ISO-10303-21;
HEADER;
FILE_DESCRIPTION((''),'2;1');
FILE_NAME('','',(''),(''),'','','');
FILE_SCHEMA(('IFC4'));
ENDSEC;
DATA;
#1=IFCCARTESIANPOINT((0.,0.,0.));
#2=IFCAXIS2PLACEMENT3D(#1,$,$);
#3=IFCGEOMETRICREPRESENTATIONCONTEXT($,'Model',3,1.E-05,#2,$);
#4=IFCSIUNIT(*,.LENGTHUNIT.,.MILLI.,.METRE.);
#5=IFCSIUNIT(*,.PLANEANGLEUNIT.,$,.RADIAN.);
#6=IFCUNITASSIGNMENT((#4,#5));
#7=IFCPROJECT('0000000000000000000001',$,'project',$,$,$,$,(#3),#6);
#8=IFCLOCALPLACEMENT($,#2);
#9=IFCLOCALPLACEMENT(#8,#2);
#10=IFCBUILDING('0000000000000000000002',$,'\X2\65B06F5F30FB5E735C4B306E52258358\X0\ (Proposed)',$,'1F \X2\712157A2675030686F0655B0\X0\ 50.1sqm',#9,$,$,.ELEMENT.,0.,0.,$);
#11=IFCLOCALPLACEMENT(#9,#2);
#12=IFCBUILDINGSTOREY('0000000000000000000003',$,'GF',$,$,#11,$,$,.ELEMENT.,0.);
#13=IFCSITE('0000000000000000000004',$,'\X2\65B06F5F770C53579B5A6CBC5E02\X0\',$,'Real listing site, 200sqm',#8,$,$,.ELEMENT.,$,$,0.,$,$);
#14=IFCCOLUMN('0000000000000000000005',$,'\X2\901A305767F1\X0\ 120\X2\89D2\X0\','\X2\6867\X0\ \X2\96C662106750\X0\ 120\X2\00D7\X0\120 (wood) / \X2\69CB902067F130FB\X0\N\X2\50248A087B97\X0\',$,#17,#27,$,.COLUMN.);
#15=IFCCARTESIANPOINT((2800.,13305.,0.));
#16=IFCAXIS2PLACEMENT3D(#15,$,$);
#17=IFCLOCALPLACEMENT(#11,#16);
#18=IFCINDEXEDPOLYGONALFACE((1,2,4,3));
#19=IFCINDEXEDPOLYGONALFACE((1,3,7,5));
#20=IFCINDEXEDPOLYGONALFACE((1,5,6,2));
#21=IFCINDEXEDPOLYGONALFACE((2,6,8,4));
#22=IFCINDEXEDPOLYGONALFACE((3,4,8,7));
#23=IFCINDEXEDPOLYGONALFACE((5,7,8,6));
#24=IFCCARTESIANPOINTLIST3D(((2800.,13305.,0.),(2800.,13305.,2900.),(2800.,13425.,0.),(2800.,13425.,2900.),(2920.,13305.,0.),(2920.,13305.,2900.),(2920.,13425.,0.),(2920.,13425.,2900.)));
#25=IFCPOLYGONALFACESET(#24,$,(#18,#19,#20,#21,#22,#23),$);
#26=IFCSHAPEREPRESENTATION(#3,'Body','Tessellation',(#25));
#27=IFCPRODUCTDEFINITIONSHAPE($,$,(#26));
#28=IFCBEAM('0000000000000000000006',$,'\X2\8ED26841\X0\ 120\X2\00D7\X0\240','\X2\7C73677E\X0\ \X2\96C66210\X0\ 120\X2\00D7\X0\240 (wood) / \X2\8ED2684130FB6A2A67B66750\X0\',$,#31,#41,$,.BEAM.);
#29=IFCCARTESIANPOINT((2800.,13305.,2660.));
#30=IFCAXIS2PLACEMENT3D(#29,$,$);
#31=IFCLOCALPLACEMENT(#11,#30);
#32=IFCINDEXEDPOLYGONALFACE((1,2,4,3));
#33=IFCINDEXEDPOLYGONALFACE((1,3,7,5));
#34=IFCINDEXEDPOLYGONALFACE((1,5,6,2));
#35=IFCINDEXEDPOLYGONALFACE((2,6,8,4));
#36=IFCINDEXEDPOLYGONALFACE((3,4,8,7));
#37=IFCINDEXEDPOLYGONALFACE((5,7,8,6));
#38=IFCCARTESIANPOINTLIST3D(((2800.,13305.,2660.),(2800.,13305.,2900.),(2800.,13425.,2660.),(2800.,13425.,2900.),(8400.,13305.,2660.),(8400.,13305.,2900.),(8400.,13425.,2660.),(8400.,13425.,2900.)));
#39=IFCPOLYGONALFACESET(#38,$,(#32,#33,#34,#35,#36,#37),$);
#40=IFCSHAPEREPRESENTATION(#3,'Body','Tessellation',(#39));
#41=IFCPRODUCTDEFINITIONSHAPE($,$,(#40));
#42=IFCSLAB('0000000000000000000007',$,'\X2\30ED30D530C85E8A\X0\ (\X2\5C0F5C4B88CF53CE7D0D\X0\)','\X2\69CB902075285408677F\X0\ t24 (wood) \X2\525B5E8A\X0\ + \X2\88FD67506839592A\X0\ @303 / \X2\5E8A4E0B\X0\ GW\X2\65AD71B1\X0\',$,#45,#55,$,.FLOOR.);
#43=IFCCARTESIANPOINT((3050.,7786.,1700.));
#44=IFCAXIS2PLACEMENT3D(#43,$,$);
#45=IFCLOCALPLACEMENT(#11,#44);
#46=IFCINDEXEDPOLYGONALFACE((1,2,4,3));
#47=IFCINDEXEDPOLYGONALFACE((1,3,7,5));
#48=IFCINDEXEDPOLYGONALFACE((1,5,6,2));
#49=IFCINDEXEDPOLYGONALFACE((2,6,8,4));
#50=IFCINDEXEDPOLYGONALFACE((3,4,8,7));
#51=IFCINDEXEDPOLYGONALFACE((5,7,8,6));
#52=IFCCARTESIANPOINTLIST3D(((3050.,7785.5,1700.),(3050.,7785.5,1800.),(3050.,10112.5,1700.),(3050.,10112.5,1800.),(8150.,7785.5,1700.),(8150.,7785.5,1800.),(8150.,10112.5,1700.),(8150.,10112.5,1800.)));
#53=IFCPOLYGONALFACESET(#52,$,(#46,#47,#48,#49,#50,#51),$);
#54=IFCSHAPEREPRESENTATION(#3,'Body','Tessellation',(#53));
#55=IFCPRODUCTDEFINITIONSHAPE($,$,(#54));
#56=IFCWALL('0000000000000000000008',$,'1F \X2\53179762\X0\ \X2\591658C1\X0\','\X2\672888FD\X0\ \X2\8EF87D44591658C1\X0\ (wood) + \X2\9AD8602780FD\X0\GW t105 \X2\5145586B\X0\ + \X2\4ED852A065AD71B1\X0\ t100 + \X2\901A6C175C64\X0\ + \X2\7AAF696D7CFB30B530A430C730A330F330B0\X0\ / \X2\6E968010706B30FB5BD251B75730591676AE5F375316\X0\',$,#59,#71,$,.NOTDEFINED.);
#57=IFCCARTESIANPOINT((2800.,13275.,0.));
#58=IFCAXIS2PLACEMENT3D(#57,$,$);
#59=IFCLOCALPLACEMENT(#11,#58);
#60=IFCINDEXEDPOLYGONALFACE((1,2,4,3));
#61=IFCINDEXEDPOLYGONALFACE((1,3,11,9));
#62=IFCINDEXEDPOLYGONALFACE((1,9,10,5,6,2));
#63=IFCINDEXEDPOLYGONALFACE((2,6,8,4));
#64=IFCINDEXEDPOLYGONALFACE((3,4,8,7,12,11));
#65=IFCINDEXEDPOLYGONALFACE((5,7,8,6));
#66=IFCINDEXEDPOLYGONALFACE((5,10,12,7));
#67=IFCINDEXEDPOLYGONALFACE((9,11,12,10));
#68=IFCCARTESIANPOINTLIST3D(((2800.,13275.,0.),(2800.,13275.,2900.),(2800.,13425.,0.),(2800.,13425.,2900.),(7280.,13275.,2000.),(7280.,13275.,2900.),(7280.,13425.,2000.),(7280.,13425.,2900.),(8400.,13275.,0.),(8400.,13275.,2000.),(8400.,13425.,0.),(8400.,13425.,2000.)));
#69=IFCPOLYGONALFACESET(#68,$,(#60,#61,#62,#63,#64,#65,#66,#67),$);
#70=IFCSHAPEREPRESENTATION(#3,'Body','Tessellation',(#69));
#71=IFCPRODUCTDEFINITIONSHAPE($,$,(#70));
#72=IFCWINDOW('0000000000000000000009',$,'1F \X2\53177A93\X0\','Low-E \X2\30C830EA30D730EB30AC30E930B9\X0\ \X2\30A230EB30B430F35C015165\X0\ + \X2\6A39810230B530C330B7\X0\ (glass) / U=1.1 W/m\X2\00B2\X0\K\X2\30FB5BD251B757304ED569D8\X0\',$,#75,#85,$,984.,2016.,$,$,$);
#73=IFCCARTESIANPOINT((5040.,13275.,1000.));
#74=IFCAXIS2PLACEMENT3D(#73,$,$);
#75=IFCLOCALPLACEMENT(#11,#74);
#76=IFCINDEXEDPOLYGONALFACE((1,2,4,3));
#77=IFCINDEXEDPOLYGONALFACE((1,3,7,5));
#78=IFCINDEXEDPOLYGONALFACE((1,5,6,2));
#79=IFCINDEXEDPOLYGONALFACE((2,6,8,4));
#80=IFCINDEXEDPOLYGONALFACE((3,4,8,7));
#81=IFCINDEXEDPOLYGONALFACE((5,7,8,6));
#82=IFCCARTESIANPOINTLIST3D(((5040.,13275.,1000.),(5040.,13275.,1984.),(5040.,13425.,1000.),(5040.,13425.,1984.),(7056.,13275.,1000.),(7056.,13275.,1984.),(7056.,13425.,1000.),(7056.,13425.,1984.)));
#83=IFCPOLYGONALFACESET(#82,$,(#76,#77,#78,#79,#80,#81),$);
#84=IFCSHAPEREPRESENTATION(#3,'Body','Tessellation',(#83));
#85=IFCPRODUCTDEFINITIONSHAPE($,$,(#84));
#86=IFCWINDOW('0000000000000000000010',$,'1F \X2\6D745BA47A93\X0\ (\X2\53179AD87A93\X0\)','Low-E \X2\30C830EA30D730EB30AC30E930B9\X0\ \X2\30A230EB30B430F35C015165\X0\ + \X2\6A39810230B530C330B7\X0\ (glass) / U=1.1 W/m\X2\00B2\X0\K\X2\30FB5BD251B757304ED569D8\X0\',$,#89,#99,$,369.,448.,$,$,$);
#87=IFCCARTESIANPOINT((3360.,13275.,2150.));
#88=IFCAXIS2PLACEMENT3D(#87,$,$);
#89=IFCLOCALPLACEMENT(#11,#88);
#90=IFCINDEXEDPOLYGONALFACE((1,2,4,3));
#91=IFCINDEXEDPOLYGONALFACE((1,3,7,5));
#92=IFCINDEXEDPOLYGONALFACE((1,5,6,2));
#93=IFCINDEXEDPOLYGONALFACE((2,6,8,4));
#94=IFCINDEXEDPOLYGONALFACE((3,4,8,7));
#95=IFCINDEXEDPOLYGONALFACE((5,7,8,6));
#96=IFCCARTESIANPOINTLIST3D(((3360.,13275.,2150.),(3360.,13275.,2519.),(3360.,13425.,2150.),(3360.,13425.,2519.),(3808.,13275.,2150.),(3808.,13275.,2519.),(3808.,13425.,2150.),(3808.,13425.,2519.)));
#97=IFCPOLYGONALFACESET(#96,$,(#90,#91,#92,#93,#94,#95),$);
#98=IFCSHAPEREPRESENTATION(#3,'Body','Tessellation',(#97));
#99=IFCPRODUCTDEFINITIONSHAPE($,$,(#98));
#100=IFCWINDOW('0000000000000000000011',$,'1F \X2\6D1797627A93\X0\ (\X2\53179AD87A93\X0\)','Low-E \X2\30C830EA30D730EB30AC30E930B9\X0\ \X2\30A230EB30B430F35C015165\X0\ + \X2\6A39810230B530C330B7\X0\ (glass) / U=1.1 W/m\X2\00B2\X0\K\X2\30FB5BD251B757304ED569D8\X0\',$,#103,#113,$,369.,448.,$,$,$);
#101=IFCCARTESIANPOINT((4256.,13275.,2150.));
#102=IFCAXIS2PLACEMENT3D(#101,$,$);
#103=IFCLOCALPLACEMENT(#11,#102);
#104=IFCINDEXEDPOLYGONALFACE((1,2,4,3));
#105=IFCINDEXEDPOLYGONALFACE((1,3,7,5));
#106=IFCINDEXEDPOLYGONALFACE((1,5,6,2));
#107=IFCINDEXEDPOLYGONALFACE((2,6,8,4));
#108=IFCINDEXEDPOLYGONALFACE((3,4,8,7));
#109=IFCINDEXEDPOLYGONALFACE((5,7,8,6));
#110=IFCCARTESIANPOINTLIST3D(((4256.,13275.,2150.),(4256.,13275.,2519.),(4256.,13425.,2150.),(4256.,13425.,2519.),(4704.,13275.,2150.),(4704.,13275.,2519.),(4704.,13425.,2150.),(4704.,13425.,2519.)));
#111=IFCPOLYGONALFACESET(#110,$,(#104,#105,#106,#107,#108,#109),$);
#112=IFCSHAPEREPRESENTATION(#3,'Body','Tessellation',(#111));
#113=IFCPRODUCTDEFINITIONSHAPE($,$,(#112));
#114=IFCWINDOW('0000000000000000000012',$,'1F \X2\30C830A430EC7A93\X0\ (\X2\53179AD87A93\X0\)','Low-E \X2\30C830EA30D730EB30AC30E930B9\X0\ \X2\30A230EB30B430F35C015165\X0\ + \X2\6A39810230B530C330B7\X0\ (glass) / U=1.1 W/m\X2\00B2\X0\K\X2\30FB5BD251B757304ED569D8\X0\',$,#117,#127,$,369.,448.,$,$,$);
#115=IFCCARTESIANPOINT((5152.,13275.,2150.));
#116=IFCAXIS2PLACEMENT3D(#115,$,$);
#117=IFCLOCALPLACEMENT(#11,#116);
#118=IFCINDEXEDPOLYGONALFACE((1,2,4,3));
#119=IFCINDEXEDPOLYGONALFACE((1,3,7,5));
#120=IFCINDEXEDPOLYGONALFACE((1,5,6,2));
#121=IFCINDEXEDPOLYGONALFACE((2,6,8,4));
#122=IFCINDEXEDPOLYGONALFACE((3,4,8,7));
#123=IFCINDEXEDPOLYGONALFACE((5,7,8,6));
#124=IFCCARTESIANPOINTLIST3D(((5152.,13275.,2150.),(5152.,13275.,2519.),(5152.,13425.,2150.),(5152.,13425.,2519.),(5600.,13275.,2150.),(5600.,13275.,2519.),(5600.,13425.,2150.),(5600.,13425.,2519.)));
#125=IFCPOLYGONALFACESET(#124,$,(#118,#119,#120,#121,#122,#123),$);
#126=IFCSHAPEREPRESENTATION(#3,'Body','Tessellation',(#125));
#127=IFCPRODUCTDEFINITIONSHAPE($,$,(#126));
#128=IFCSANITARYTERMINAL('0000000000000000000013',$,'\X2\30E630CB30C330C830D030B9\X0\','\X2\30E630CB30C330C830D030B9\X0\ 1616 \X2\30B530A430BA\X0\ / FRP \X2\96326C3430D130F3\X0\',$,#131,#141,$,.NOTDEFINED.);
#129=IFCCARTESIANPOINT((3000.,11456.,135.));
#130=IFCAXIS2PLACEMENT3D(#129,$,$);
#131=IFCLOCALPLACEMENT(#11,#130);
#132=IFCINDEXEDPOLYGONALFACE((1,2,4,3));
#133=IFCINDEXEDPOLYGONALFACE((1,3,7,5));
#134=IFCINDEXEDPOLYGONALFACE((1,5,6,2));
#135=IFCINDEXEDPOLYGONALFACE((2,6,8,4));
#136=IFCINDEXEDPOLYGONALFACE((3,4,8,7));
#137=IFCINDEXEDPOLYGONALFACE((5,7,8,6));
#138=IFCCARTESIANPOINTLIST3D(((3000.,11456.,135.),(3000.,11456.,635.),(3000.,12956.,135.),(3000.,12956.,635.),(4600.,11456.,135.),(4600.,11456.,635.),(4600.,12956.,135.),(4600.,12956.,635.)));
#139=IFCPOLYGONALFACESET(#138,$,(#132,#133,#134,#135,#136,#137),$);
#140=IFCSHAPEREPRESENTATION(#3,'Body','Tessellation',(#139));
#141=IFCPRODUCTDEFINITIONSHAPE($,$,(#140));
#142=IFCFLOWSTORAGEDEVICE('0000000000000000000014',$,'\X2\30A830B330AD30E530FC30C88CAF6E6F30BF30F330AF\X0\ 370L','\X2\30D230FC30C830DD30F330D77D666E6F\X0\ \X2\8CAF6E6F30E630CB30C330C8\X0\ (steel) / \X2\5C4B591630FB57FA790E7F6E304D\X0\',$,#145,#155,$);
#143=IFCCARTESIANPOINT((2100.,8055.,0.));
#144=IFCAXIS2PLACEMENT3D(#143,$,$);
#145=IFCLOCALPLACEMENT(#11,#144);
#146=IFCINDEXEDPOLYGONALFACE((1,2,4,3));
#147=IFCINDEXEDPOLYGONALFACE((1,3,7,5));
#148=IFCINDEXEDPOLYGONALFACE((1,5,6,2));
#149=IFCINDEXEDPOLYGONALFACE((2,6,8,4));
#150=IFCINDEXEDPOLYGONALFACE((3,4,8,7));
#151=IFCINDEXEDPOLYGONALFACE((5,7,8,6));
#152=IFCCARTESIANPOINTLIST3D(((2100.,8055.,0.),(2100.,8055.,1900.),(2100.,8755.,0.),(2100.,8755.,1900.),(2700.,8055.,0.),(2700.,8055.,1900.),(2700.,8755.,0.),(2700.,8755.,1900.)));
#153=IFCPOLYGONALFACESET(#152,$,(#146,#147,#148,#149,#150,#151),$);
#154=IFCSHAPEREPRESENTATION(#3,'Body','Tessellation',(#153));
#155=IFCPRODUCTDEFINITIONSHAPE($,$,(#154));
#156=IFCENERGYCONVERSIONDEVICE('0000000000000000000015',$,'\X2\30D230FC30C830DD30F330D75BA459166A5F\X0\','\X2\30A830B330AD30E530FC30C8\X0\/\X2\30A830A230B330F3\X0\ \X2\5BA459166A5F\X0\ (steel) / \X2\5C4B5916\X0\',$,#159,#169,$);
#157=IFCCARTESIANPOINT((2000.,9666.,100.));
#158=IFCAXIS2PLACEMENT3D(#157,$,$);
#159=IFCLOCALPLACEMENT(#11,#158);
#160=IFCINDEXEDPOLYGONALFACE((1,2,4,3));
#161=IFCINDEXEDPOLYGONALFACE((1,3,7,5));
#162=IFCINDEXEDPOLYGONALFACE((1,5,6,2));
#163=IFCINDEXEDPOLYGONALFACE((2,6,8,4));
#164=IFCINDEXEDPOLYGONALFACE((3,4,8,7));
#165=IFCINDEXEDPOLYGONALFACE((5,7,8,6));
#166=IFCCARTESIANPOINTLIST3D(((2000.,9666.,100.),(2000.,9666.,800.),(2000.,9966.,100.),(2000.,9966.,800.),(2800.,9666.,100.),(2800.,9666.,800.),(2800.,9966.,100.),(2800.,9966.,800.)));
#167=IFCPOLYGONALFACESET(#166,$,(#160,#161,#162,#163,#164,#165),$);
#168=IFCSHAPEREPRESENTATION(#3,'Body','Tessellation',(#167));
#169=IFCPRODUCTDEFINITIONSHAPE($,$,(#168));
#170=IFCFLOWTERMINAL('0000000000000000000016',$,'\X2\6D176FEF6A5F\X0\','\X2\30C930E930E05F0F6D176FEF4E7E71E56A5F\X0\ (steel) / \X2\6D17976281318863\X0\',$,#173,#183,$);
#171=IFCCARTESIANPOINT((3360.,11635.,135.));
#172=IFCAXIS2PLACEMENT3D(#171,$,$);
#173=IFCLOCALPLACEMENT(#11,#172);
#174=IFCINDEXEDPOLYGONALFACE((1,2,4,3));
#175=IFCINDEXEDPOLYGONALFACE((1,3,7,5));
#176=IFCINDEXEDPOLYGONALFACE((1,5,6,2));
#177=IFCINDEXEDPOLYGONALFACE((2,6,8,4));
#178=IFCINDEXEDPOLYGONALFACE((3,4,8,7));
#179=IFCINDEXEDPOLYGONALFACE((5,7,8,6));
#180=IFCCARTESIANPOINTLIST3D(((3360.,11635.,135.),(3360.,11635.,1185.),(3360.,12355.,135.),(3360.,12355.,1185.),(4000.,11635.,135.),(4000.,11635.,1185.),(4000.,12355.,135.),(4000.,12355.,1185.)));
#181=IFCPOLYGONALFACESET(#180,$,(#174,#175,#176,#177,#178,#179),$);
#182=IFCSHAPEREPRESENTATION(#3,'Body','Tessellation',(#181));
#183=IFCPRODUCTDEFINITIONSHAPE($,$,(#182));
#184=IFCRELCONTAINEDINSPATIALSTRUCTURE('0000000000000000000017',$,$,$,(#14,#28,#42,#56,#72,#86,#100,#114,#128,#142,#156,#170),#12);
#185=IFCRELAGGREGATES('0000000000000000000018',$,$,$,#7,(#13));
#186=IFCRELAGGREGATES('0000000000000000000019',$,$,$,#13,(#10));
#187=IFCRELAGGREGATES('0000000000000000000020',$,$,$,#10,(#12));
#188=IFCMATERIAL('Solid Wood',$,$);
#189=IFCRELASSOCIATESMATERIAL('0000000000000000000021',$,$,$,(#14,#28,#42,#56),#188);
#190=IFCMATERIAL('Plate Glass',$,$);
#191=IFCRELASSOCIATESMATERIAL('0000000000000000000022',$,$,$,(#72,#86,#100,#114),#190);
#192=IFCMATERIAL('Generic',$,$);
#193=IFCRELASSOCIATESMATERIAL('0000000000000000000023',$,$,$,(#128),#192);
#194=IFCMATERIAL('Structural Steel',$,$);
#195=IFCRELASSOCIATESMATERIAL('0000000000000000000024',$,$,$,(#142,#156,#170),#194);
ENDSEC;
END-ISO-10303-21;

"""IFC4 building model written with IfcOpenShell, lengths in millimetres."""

from ifc_helpers import new_model, si_unit, frame, frame_2d, origin, place, context, project, spatial, rectangle, extrude, material, element, fill, save


model = new_model("IFC4")

# Units and contexts
model_context = context("Model", 3, precision=1e-05, world=origin())
ifc_project = project(units=[si_unit("LENGTHUNIT", "METRE", prefix="MILLI"), si_unit("PLANEANGLEUNIT", "RADIAN")], contexts=[model_context])

# Site, building, storey
site_placement = place(None, origin())
site = spatial("IfcSite", under=ifc_project, at=site_placement, Name="新潟県南魚沼市", ObjectType="Real listing site, 200sqm", CompositionType="ELEMENT", RefElevation=0.0)
building_placement = place(site_placement, origin())
building = spatial("IfcBuilding", under=site, at=building_placement, Name="新潟・平屋の別荘 (Proposed)", ObjectType="1F 無垢材と漆喰 50.1sqm", CompositionType="ELEMENT", ElevationOfRefHeight=0.0, ElevationOfTerrain=0.0)
storey_placement = place(building_placement, origin())
storey = spatial("IfcBuildingStorey", under=building, at=storey_placement, Name="GF", CompositionType="ELEMENT", Elevation=0.0)

# Column
ifc_material_1 = material(Name="Solid Wood")
column_1_placement = place(storey_placement, frame((2800.0, 13305.0, 0.0)))
element("IfcColumn", 1, at=column_1_placement, inside=storey, material=ifc_material_1, Name="通し柱 120角", Description="桧 集成材 120×120 (wood) / 構造柱・N値計算", PredefinedType="COLUMN", context=model_context, shape_type="SweptSolid", body=[
    extrude(rectangle(XDim=120.0, YDim=120.0, at=frame_2d((60.0, 60.0))), frame((2800.0, 13305.0, 0.0)), (0.0, 0.0, 1.0), 2900.0),
])

# Beam
beam_1_placement = place(storey_placement, frame((2800.0, 13305.0, 2660.0)))
element("IfcBeam", 2, at=beam_1_placement, inside=storey, material=ifc_material_1, Name="軒桁 120×240", Description="米松 集成 120×240 (wood) / 軒桁・横架材", PredefinedType="BEAM", context=model_context, shape_type="SweptSolid", body=[
    extrude(rectangle(XDim=5600.0, YDim=120.0, at=frame_2d((2800.0, 60.0))), frame((2800.0, 13305.0, 2660.0)), (0.0, 0.0, 1.0), 240.0),
])

# Slab
slab_placement = place(storey_placement, frame((3050.0, 7786.0, 1700.0)))
element("IfcSlab", 3, at=slab_placement, inside=storey, material=ifc_material_1, Name="ロフト床 (小屋裏収納)", Description="構造用合板 t24 (wood) 剛床 + 製材根太 @303 / 床下 GW断熱", PredefinedType="FLOOR", context=model_context, shape_type="SweptSolid", body=[
    extrude(rectangle(XDim=5100.0, YDim=2327.0, at=frame_2d((2550.0, 1163.0))), frame((3050.0, 7786.0, 1700.0)), (0.0, 0.0, 1.0), 100.0),
])

# Wall, openings, windows
wall_1_placement = place(storey_placement, frame((2800.0, 13275.0, 0.0)))
wall_1 = element("IfcWall", 4, at=wall_1_placement, inside=storey, material=ifc_material_1, Name="1F 北面 外壁", Description="木製 軸組外壁 (wood) + 高性能GW t105 充填 + 付加断熱 t100 + 通気層 + 窯業系サイディング / 準耐火・寒冷地外皮強化", PredefinedType="NOTDEFINED", context=model_context, shape_type="SweptSolid", body=[
    extrude(rectangle(XDim=5600.0, YDim=150.0, at=frame_2d((2800.0, 75.0))), frame((2800.0, 13275.0, 0.0)), (0.0, 0.0, 1.0), 2900.0),
])
opening_1_placement = place(storey_placement, frame((5040.0, 13275.0, 1000.0)))
opening_1 = element("IfcOpeningElement", 5, at=opening_1_placement, cuts=wall_1, PredefinedType="NOTDEFINED", context=model_context, shape_type="SweptSolid", body=[
    extrude(rectangle(XDim=2016.0, YDim=150.0, at=frame_2d((1008.0, 75.0))), frame((5040.0, 13275.0, 1000.0)), (0.0, 0.0, 1.0), 984.0),
])
opening_2_placement = place(storey_placement, frame((3360.0, 13275.0, 2150.0)))
opening_2 = element("IfcOpeningElement", 6, at=opening_2_placement, cuts=wall_1, PredefinedType="NOTDEFINED", context=model_context, shape_type="SweptSolid", body=[
    extrude(rectangle(XDim=448.0, YDim=150.0, at=frame_2d((224.0, 75.0))), frame((3360.0, 13275.0, 2150.0)), (0.0, 0.0, 1.0), 369.0),
])
opening_3_placement = place(storey_placement, frame((4256.0, 13275.0, 2150.0)))
opening_3 = element("IfcOpeningElement", 7, at=opening_3_placement, cuts=wall_1, PredefinedType="NOTDEFINED", context=model_context, shape_type="SweptSolid", body=[
    extrude(rectangle(XDim=448.0, YDim=150.0, at=frame_2d((224.0, 75.0))), frame((4256.0, 13275.0, 2150.0)), (0.0, 0.0, 1.0), 369.0),
])
opening_4_placement = place(storey_placement, frame((5152.0, 13275.0, 2150.0)))
opening_4 = element("IfcOpeningElement", 8, at=opening_4_placement, cuts=wall_1, PredefinedType="NOTDEFINED", context=model_context, shape_type="SweptSolid", body=[
    extrude(rectangle(XDim=448.0, YDim=150.0, at=frame_2d((224.0, 75.0))), frame((5152.0, 13275.0, 2150.0)), (0.0, 0.0, 1.0), 369.0),
])
ifc_material_2 = material(Name="Plate Glass")
window_1_placement = place(storey_placement, frame((5040.0, 13275.0, 1000.0)))
window_1 = element("IfcWindow", 9, at=window_1_placement, inside=storey, material=ifc_material_2, Name="1F 北窓", Description="Low-E トリプルガラス アルゴン封入 + 樹脂サッシ (glass) / U=1.1 W/m²K・寒冷地仕様", OverallHeight=984.0, OverallWidth=2016.0, context=model_context, shape_type="SweptSolid", body=[
    extrude(rectangle(XDim=2016.0, YDim=150.0, at=frame_2d((1008.0, 75.0))), frame((5040.0, 13275.0, 1000.0)), (0.0, 0.0, 1.0), 984.0),
])
fill(opening_1, window_1)
window_2_placement = place(storey_placement, frame((3360.0, 13275.0, 2150.0)))
window_2 = element("IfcWindow", 10, at=window_2_placement, inside=storey, material=ifc_material_2, Name="1F 浴室窓 (北高窓)", Description="Low-E トリプルガラス アルゴン封入 + 樹脂サッシ (glass) / U=1.1 W/m²K・寒冷地仕様", OverallHeight=369.0, OverallWidth=448.0, context=model_context, shape_type="SweptSolid", body=[
    extrude(rectangle(XDim=448.0, YDim=150.0, at=frame_2d((224.0, 75.0))), frame((3360.0, 13275.0, 2150.0)), (0.0, 0.0, 1.0), 369.0),
])
fill(opening_2, window_2)
window_3_placement = place(storey_placement, frame((4256.0, 13275.0, 2150.0)))
window_3 = element("IfcWindow", 11, at=window_3_placement, inside=storey, material=ifc_material_2, Name="1F 洗面窓 (北高窓)", Description="Low-E トリプルガラス アルゴン封入 + 樹脂サッシ (glass) / U=1.1 W/m²K・寒冷地仕様", OverallHeight=369.0, OverallWidth=448.0, context=model_context, shape_type="SweptSolid", body=[
    extrude(rectangle(XDim=448.0, YDim=150.0, at=frame_2d((224.0, 75.0))), frame((4256.0, 13275.0, 2150.0)), (0.0, 0.0, 1.0), 369.0),
])
fill(opening_3, window_3)
window_4_placement = place(storey_placement, frame((5152.0, 13275.0, 2150.0)))
window_4 = element("IfcWindow", 12, at=window_4_placement, inside=storey, material=ifc_material_2, Name="1F トイレ窓 (北高窓)", Description="Low-E トリプルガラス アルゴン封入 + 樹脂サッシ (glass) / U=1.1 W/m²K・寒冷地仕様", OverallHeight=369.0, OverallWidth=448.0, context=model_context, shape_type="SweptSolid", body=[
    extrude(rectangle(XDim=448.0, YDim=150.0, at=frame_2d((224.0, 75.0))), frame((5152.0, 13275.0, 2150.0)), (0.0, 0.0, 1.0), 369.0),
])
fill(opening_4, window_4)

# Sanitary terminal
ifc_material_3 = material(Name="Generic")
sanitary_terminal_placement = place(storey_placement, frame((3000.0, 11456.0, 135.0)))
element("IfcSanitaryTerminal", 13, at=sanitary_terminal_placement, inside=storey, material=ifc_material_3, Name="ユニットバス", Description="ユニットバス 1616 サイズ / FRP 防水パン", PredefinedType="NOTDEFINED", context=model_context, shape_type="SweptSolid", body=[
    extrude(rectangle(XDim=1600.0, YDim=1500.0, at=frame_2d((800.0, 750.0))), frame((3000.0, 11456.0, 135.0)), (0.0, 0.0, 1.0), 500.0),
])

# Flow storage device
ifc_material_4 = material(Name="Structural Steel")
flow_storage_device_placement = place(storey_placement, frame((2100.0, 8055.0, 0.0)))
element("IfcFlowStorageDevice", 14, at=flow_storage_device_placement, inside=storey, material=ifc_material_4, Name="エコキュート貯湯タンク 370L", Description="ヒートポンプ給湯 貯湯ユニット (steel) / 屋外・基礎置き", context=model_context, shape_type="SweptSolid", body=[
    extrude(rectangle(XDim=600.0, YDim=700.0, at=frame_2d((300.0, 350.0))), frame((2100.0, 8055.0, 0.0)), (0.0, 0.0, 1.0), 1900.0),
])

# Energy conversion device
energy_conversion_device_placement = place(storey_placement, frame((2000.0, 9666.0, 100.0)))
element("IfcEnergyConversionDevice", 15, at=energy_conversion_device_placement, inside=storey, material=ifc_material_4, Name="ヒートポンプ室外機", Description="エコキュート/エアコン 室外機 (steel) / 屋外", context=model_context, shape_type="SweptSolid", body=[
    extrude(rectangle(XDim=800.0, YDim=300.0, at=frame_2d((400.0, 150.0))), frame((2000.0, 9666.0, 100.0)), (0.0, 0.0, 1.0), 700.0),
])

# Flow terminal
flow_terminal_placement = place(storey_placement, frame((3360.0, 11635.0, 135.0)))
element("IfcFlowTerminal", 16, at=flow_terminal_placement, inside=storey, material=ifc_material_4, Name="洗濯機", Description="ドラム式洗濯乾燥機 (steel) / 洗面脱衣", context=model_context, shape_type="SweptSolid", body=[
    extrude(rectangle(XDim=640.0, YDim=720.0, at=frame_2d((320.0, 360.0))), frame((3360.0, 11635.0, 135.0)), (0.0, 0.0, 1.0), 1050.0),
])

save(model, "model.ifc")
